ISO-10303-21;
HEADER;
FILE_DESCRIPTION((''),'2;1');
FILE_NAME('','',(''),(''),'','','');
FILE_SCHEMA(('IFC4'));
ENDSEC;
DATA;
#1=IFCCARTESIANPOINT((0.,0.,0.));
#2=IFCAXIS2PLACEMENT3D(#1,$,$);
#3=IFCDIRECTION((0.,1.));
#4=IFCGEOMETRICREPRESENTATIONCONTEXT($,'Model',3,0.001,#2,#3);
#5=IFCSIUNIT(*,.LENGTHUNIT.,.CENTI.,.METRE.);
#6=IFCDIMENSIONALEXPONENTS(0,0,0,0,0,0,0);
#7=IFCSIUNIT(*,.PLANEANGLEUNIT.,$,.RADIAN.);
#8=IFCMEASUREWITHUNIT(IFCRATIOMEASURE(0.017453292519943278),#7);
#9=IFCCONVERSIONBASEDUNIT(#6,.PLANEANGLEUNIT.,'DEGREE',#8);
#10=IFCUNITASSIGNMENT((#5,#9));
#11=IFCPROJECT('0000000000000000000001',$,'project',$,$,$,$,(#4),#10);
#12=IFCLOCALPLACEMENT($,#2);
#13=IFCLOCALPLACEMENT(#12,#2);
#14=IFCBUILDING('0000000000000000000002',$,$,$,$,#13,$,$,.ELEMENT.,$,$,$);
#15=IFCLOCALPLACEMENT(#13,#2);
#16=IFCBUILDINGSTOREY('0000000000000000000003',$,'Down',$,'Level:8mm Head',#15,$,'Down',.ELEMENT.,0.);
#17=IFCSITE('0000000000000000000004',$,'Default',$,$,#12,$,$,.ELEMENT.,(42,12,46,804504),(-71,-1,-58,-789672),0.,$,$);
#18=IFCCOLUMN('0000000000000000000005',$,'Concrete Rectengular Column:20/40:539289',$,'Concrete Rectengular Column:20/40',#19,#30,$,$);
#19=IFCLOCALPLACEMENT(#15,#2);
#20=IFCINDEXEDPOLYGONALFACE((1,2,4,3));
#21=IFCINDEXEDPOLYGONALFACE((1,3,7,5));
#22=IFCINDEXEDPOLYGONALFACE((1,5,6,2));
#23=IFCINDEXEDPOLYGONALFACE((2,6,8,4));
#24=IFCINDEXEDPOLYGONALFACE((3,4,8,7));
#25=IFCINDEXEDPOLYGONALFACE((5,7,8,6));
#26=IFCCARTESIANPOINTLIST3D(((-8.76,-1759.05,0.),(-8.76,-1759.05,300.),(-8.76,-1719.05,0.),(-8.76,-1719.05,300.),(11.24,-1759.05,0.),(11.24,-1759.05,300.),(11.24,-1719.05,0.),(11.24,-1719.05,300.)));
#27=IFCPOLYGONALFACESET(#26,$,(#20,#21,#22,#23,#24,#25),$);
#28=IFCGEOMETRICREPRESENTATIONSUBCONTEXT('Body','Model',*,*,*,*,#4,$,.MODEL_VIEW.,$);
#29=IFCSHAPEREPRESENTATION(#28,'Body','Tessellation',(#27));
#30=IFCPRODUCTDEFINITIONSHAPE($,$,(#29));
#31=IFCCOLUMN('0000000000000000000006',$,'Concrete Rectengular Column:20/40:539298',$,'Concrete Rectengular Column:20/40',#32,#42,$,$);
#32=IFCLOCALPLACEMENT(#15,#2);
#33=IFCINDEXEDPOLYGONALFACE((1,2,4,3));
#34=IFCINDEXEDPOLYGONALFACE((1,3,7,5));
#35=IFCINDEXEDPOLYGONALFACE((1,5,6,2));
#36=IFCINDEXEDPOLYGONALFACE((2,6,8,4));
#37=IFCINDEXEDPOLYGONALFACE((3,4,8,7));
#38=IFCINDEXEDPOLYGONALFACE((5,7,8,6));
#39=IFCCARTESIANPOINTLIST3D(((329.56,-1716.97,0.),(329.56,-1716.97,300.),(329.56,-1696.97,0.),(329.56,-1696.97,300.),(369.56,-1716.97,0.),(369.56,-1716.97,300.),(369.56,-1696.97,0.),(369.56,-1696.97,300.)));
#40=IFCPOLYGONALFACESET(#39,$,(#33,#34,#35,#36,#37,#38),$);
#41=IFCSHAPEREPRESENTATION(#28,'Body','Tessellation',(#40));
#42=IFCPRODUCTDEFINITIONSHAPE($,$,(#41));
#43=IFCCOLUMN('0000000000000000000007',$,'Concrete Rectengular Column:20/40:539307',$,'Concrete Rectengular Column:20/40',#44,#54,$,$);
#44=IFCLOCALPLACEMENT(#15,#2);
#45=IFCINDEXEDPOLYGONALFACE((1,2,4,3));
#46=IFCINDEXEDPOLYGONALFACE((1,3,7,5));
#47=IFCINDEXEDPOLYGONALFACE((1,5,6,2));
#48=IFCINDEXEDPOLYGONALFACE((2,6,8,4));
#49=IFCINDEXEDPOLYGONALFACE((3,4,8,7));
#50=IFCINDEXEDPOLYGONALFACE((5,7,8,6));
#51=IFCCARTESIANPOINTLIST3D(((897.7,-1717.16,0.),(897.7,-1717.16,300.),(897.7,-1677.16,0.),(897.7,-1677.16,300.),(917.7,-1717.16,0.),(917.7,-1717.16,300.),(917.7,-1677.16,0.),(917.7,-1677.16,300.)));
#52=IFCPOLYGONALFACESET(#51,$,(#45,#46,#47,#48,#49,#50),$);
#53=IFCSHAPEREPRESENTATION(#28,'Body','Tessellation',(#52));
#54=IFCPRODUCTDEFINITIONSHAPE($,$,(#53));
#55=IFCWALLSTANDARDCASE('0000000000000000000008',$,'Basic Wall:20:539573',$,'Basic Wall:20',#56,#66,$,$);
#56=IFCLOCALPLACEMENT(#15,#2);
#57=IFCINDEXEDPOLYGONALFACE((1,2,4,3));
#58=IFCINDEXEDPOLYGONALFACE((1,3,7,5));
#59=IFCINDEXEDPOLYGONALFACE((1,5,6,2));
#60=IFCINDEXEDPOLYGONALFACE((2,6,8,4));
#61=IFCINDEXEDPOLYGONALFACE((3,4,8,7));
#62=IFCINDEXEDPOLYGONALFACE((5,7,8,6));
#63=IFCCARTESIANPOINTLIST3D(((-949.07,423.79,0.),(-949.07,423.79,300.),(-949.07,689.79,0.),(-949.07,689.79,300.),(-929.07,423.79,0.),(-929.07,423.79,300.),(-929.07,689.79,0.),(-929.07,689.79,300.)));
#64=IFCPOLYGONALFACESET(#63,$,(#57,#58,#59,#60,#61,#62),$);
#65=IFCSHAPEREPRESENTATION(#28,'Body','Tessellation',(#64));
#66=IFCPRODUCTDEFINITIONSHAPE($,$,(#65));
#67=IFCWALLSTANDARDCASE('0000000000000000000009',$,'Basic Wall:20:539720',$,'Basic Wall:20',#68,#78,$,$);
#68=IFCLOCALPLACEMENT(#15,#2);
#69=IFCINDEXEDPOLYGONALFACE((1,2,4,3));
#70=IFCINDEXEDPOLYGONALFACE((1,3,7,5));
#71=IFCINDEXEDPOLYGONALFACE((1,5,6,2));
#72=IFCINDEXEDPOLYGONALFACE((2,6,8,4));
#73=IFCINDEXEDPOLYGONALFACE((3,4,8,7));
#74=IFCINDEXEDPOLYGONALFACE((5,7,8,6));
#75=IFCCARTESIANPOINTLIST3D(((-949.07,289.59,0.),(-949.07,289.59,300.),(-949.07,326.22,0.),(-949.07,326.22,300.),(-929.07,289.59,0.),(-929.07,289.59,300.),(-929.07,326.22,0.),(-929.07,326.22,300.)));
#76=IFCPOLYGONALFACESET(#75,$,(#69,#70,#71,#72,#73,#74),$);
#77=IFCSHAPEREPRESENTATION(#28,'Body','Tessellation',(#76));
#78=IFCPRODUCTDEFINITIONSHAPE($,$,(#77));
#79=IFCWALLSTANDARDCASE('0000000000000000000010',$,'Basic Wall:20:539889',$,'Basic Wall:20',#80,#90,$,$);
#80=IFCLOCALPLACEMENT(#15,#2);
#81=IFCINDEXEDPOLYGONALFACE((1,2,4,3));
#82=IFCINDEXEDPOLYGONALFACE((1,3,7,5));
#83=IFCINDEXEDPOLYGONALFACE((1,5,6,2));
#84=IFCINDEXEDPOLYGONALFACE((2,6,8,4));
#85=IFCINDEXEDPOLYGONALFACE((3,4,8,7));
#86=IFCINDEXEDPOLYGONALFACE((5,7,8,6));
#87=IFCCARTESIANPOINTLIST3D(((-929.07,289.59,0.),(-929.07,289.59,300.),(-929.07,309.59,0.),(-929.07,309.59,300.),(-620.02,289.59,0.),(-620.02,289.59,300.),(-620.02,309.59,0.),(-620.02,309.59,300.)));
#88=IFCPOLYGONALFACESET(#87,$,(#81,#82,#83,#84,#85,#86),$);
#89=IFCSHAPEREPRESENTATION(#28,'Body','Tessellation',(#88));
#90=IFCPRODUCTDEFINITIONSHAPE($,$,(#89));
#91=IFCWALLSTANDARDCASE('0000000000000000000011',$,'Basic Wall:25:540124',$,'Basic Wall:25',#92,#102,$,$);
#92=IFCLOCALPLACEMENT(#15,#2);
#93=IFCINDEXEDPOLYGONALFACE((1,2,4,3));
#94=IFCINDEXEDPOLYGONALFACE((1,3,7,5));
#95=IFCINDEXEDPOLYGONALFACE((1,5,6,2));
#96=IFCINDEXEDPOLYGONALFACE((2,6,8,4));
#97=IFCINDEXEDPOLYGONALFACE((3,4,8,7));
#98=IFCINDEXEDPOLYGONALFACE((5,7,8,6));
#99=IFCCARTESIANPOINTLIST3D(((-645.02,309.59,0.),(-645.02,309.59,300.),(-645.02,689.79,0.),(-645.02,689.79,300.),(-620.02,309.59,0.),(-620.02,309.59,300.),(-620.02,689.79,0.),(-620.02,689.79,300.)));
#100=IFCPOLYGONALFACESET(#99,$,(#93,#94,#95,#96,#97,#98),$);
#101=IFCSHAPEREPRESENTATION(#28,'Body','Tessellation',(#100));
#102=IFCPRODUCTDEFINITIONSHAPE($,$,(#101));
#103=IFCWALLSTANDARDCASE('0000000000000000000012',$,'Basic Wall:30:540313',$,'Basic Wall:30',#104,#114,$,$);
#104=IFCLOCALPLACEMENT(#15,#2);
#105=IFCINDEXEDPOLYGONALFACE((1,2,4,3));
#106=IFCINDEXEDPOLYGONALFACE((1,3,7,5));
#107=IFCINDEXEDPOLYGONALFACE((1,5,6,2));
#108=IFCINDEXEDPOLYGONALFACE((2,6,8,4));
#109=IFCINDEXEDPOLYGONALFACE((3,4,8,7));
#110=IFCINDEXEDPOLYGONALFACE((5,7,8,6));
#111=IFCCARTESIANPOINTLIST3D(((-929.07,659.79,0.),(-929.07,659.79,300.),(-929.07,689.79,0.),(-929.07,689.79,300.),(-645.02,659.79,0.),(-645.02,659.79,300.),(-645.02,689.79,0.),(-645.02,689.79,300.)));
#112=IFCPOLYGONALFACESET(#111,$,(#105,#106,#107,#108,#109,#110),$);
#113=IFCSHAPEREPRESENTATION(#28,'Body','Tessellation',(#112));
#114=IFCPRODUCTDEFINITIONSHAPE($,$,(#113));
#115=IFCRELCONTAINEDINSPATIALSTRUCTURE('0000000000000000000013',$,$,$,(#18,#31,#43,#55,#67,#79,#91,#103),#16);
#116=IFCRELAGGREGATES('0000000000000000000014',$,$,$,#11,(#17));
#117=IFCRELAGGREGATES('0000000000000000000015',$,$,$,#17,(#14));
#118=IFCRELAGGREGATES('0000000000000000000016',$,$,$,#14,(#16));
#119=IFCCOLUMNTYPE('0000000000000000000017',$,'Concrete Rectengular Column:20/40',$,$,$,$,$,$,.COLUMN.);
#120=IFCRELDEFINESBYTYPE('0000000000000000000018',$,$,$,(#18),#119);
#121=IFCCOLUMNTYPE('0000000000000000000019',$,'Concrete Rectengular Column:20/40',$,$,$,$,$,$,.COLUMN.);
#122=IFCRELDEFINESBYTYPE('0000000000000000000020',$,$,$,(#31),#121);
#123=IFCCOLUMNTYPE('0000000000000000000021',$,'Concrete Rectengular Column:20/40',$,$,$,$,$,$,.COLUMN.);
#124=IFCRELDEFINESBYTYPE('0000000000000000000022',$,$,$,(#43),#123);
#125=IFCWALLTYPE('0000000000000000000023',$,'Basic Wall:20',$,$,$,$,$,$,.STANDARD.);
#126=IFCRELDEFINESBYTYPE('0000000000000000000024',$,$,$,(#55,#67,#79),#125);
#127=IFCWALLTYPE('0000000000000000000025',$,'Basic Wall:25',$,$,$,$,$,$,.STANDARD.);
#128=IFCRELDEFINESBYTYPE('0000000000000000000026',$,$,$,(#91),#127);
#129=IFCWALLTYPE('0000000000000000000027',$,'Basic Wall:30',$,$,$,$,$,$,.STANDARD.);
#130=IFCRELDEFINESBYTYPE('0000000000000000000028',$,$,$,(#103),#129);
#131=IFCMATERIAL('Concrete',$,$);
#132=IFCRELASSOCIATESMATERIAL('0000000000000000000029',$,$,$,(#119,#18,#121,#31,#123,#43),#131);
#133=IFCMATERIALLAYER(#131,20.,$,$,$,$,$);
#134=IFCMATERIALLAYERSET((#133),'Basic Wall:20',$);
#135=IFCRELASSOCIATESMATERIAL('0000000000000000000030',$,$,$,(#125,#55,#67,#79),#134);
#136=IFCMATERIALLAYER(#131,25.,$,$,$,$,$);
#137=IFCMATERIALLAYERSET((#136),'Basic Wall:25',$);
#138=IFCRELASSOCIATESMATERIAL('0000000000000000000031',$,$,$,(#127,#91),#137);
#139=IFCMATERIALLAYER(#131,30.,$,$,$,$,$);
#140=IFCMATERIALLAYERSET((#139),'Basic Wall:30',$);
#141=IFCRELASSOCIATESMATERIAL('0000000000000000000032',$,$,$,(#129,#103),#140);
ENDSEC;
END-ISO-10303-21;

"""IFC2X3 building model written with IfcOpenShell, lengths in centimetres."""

from ifc_helpers import new_model, entity, si_unit, converted_unit, direction, frame, frame_2d, origin, origin_2d_with_axis, place, context, subcontext, project, spatial, rectangle, extrude, source, transform, mapped, material, layer, layer_set, layer_usage, type_object, type_shapes, element, save


model = new_model("IFC2X3")

# Units and contexts
model_context = context("Model", 3, precision=0.001, world=origin(), true_north=direction((0.0, 1.0)))
body_context = subcontext(model_context, "Body", "Model", "MODEL_VIEW")
ifc_project = project(units=[si_unit("LENGTHUNIT", "METRE", prefix="CENTI"), converted_unit("PLANEANGLEUNIT", "DEGREE", entity("IfcRatioMeasure", 0.017453292519943278), si_unit("PLANEANGLEUNIT", "RADIAN"), dimensions=[0, 0, 0, 0, 0, 0, 0])], contexts=[model_context])

# Site, building, storey
site_placement = place(None, origin())
site = spatial("IfcSite", under=ifc_project, at=site_placement, Name="Default", CompositionType="ELEMENT", RefLatitude=(42, 12, 46, 804504), RefLongitude=(-71, -1, -58, -789672), RefElevation=0.0)
building_placement = place(site_placement, origin())
building = spatial("IfcBuilding", under=site, at=building_placement, CompositionType="ELEMENT")
storey_placement = place(building_placement, origin())
storey = spatial("IfcBuildingStorey", under=building, at=storey_placement, Name="Down", ObjectType="Level:8mm Head", LongName="Down", CompositionType="ELEMENT", Elevation=0.0)

# Columns
ifc_material = material(Name="Concrete")
column_type_1 = type_object("IfcColumnType", Name="Concrete Rectengular Column:20/40", PredefinedType="COLUMN", material=ifc_material)
shared_shape_1 = source(origin(), body_context, "Body", "SweptSolid", [
    extrude(rectangle(XDim=40.0, YDim=20.0, at=origin_2d_with_axis()), frame((1.24, -1739.05, 0.0), z_axis=(0.0, 0.0, 1.0), x_axis=(0.0, -1.0, 0.0)), (0.0, 0.0, 1.0), 300.0),
])
type_shapes(column_type_1, [shared_shape_1])
column_1_placement = place(storey_placement, origin())
element("IfcColumn", 1, at=column_1_placement, inside=storey, type_object=column_type_1, material=ifc_material, Name="Concrete Rectengular Column:20/40:539289", ObjectType="Concrete Rectengular Column:20/40", context=body_context, shape_type="MappedRepresentation", body=[
    mapped(shared_shape_1, transform((0.0, 0.0, 0.0), scale=1.0)),
])
column_type_2 = type_object("IfcColumnType", Name="Concrete Rectengular Column:20/40", PredefinedType="COLUMN", material=ifc_material)
shared_shape_2 = source(origin(), body_context, "Body", "SweptSolid", [
    extrude(rectangle(XDim=20.0, YDim=40.0, at=frame_2d((0.0, 0.0), x_axis=(1.0, 0.0))), frame((349.56, -1706.97, 0.0), z_axis=(0.0, 0.0, 1.0), x_axis=(0.0, -1.0, 0.0)), (0.0, 0.0, 1.0), 300.0),
])
type_shapes(column_type_2, [shared_shape_2])
column_2_placement = place(storey_placement, origin())
element("IfcColumn", 2, at=column_2_placement, inside=storey, type_object=column_type_2, material=ifc_material, Name="Concrete Rectengular Column:20/40:539298", ObjectType="Concrete Rectengular Column:20/40", context=body_context, shape_type="MappedRepresentation", body=[
    mapped(shared_shape_2, transform((0.0, 0.0, 0.0), scale=1.0)),
])
column_type_3 = type_object("IfcColumnType", Name="Concrete Rectengular Column:20/40", PredefinedType="COLUMN", material=ifc_material)
shared_shape_3 = source(origin(), body_context, "Body", "SweptSolid", [
    extrude(rectangle(XDim=40.0, YDim=20.0, at=origin_2d_with_axis()), frame((907.7, -1697.16, 0.0), z_axis=(0.0, 0.0, 1.0), x_axis=(0.0, -1.0, 0.0)), (0.0, 0.0, 1.0), 300.0),
])
type_shapes(column_type_3, [shared_shape_3])
column_3_placement = place(storey_placement, origin())
element("IfcColumn", 3, at=column_3_placement, inside=storey, type_object=column_type_3, material=ifc_material, Name="Concrete Rectengular Column:20/40:539307", ObjectType="Concrete Rectengular Column:20/40", context=body_context, shape_type="MappedRepresentation", body=[
    mapped(shared_shape_3, transform((0.0, 0.0, 0.0), scale=1.0)),
])

# Walls
ifc_layer_1 = layer(ifc_material, 20.0)
ifc_layer_set_1 = layer_set([ifc_layer_1], Name="Basic Wall:20")
ifc_layer_usage_1 = layer_usage(ifc_layer_set_1, "AXIS2", "POSITIVE", -10.0)
wall_type_1 = type_object("IfcWallType", Name="Basic Wall:20", PredefinedType="STANDARD", material=ifc_layer_set_1)
wall_1_placement = place(storey_placement, frame((-939.07, 689.79, 0.0), z_axis=(0.0, 0.0, 1.0), x_axis=(0.0, -1.0, 0.0)))
element("IfcWallStandardCase", 4, at=wall_1_placement, inside=storey, type_object=wall_type_1, material=ifc_layer_usage_1, Name="Basic Wall:20:539573", ObjectType="Basic Wall:20", context=body_context, shape_type="SweptSolid", body=[
    extrude(rectangle(XDim=266.0, YDim=20.0, at=frame_2d((133.0, 0.0), x_axis=(-1.0, 0.0))), origin(), (0.0, 0.0, 1.0), 300.0),
])
ifc_layer_usage_2 = layer_usage(ifc_layer_set_1, "AXIS2", "POSITIVE", -10.0)
wall_2_placement = place(storey_placement, frame((-939.07, 326.22, 0.0), z_axis=(0.0, 0.0, 1.0), x_axis=(0.0, -1.0, 0.0)))
element("IfcWallStandardCase", 5, at=wall_2_placement, inside=storey, type_object=wall_type_1, material=ifc_layer_usage_2, Name="Basic Wall:20:539720", ObjectType="Basic Wall:20", context=body_context, shape_type="SweptSolid", body=[
    extrude(rectangle(XDim=36.63, YDim=20.0, at=frame_2d((18.31, 0.0), x_axis=(-1.0, 0.0))), origin(), (0.0, 0.0, 1.0), 300.0),
])
ifc_layer_usage_3 = layer_usage(ifc_layer_set_1, "AXIS2", "POSITIVE", -10.0)
wall_3_placement = place(storey_placement, frame((-929.07, 299.59, 0.0)))
element("IfcWallStandardCase", 6, at=wall_3_placement, inside=storey, type_object=wall_type_1, material=ifc_layer_usage_3, Name="Basic Wall:20:539889", ObjectType="Basic Wall:20", context=body_context, shape_type="SweptSolid", body=[
    extrude(rectangle(XDim=309.05, YDim=20.0, at=frame_2d((154.53, 0.0), x_axis=(-1.0, 0.0))), origin(), (0.0, 0.0, 1.0), 300.0),
])
ifc_layer_2 = layer(ifc_material, 25.0)
ifc_layer_set_2 = layer_set([ifc_layer_2], Name="Basic Wall:25")
ifc_layer_usage_4 = layer_usage(ifc_layer_set_2, "AXIS2", "POSITIVE", -12.5)
wall_type_2 = type_object("IfcWallType", Name="Basic Wall:25", PredefinedType="STANDARD", material=ifc_layer_set_2)
wall_4_placement = place(storey_placement, frame((-632.52, 309.59, 0.0), z_axis=(0.0, 0.0, 1.0), x_axis=(0.0, 1.0, 0.0)))
element("IfcWallStandardCase", 7, at=wall_4_placement, inside=storey, type_object=wall_type_2, material=ifc_layer_usage_4, Name="Basic Wall:25:540124", ObjectType="Basic Wall:25", context=body_context, shape_type="SweptSolid", body=[
    extrude(rectangle(XDim=380.2, YDim=25.0, at=frame_2d((190.1, 0.0), x_axis=(-1.0, 0.0))), origin(), (0.0, 0.0, 1.0), 300.0),
])
ifc_layer_3 = layer(ifc_material, 30.0)
ifc_layer_set_3 = layer_set([ifc_layer_3], Name="Basic Wall:30")
ifc_layer_usage_5 = layer_usage(ifc_layer_set_3, "AXIS2", "POSITIVE", -15.0)
wall_type_3 = type_object("IfcWallType", Name="Basic Wall:30", PredefinedType="STANDARD", material=ifc_layer_set_3)
wall_5_placement = place(storey_placement, frame((-645.02, 674.79, 0.0), z_axis=(0.0, 0.0, 1.0), x_axis=(-1.0, 0.0, 0.0)))
element("IfcWallStandardCase", 8, at=wall_5_placement, inside=storey, type_object=wall_type_3, material=ifc_layer_usage_5, Name="Basic Wall:30:540313", ObjectType="Basic Wall:30", context=body_context, shape_type="SweptSolid", body=[
    extrude(rectangle(XDim=284.05, YDim=30.0, at=frame_2d((142.03, 0.0), x_axis=(-1.0, 0.0))), origin(), (0.0, 0.0, 1.0), 300.0),
])

save(model, "model.ifc")
